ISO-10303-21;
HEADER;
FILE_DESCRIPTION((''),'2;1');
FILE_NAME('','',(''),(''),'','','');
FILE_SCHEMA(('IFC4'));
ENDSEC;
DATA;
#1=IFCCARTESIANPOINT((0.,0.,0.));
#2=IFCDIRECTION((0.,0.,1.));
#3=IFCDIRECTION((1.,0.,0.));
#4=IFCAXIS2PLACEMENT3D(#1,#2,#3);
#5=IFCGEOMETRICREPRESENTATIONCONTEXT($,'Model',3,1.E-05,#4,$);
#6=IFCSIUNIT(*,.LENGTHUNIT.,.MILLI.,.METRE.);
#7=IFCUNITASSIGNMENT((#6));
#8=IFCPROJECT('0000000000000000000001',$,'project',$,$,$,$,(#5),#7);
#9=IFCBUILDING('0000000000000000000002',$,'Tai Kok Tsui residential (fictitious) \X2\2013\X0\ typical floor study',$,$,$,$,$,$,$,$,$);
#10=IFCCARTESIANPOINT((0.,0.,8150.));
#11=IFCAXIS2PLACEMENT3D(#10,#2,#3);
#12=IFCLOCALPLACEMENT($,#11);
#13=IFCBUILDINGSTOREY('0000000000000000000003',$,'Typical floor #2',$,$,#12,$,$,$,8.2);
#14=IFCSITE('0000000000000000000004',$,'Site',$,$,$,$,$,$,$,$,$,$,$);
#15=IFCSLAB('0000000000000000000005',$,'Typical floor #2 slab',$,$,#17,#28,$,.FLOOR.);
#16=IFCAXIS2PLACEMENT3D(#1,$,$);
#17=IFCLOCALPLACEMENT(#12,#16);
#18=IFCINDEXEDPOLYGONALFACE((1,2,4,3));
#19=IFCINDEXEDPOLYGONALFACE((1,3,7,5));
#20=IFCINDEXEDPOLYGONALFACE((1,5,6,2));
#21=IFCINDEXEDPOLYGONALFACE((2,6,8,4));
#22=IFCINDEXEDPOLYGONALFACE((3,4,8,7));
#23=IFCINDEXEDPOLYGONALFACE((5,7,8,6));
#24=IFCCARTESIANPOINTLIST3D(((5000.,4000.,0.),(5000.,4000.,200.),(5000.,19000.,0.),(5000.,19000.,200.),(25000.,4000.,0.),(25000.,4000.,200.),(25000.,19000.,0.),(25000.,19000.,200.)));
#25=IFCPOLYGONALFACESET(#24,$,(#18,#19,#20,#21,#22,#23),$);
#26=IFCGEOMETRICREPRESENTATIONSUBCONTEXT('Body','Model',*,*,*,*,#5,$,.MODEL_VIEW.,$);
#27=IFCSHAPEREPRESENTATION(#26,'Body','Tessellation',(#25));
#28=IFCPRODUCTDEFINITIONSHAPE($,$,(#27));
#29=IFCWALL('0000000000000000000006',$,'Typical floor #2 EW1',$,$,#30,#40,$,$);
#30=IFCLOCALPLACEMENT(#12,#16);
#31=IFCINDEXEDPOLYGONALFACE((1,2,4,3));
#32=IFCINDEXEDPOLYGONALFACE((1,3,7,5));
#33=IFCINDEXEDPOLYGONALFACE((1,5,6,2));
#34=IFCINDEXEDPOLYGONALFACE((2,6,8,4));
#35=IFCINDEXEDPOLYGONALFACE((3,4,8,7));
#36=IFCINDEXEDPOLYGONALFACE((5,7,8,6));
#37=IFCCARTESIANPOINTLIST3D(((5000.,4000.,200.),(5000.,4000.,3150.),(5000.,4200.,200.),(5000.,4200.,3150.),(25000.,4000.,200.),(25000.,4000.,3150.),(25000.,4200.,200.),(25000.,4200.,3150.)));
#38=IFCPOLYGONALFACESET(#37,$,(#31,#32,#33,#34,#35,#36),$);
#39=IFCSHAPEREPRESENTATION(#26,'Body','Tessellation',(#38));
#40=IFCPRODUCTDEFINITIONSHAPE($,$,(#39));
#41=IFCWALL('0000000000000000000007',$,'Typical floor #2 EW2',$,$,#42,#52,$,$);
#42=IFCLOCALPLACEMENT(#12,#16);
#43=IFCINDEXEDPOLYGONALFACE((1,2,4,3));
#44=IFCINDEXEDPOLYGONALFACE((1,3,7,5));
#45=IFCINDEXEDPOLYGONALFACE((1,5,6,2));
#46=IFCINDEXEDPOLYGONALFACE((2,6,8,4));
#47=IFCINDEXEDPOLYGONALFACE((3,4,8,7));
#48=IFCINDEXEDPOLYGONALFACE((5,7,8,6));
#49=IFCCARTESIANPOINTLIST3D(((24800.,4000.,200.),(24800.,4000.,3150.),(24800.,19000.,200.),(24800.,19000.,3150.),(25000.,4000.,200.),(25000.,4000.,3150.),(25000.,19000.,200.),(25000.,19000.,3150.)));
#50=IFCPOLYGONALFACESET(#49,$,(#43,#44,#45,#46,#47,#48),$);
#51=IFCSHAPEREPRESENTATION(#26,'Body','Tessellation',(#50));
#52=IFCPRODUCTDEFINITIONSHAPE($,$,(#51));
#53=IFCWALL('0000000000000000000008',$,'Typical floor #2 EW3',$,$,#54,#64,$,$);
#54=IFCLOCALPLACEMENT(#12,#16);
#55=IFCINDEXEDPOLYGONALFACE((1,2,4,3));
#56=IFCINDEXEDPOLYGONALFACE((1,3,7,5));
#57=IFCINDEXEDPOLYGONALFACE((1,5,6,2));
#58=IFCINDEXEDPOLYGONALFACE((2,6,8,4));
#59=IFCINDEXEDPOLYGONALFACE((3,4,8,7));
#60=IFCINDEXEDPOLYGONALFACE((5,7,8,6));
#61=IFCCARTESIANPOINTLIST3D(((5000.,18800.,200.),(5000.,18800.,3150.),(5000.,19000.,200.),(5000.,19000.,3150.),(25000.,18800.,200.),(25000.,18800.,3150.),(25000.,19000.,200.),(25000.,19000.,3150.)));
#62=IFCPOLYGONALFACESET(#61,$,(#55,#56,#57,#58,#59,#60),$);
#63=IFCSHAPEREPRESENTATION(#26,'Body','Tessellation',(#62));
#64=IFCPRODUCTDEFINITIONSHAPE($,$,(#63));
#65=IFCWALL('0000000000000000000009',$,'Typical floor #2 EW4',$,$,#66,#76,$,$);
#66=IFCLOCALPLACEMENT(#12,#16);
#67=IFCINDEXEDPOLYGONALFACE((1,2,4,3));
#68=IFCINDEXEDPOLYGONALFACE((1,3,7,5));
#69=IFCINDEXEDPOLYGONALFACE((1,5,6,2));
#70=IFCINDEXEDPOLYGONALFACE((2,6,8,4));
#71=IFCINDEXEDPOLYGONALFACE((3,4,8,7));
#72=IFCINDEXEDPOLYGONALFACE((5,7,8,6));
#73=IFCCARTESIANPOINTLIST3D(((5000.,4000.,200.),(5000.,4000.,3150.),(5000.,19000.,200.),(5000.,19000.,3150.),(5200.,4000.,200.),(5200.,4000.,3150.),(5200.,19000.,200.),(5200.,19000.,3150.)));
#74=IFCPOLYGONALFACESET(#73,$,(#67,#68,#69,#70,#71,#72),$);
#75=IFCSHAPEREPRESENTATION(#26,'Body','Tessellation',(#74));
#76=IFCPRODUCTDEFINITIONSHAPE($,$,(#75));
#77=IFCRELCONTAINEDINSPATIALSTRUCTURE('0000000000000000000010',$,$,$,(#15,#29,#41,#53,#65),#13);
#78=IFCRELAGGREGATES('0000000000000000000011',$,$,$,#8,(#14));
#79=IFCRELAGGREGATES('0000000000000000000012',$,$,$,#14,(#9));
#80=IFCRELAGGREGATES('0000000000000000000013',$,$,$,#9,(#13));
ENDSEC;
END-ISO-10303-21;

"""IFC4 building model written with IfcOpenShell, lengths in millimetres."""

from ifc_helpers import new_model, si_unit, frame, origin_with_axes, place, context, subcontext, project, spatial, indexed_curve, outline, extrude, element, save


model = new_model("IFC4")

# Units and contexts
model_context = context("Model", 3, precision=1e-05, world=origin_with_axes())
body_context = subcontext(model_context, "Body", "Model", "MODEL_VIEW")
ifc_project = project(units=[si_unit("LENGTHUNIT", "METRE", prefix="MILLI")], contexts=[model_context])

# Site, building, storey
site = spatial("IfcSite", under=ifc_project, Name="Site")
building = spatial("IfcBuilding", under=site, Name="Tai Kok Tsui residential (fictitious) – typical floor study")
storey_placement = place(None, frame((0.0, 0.0, 8150.0), z_axis=(0.0, 0.0, 1.0), x_axis=(1.0, 0.0, 0.0)))
storey = spatial("IfcBuildingStorey", under=building, at=storey_placement, Name="Typical floor #2", Elevation=8.2)

# Slab
slab_placement = place(storey_placement, origin_with_axes())
element("IfcSlab", 1, at=slab_placement, inside=storey, Name="Typical floor #2 slab", PredefinedType="FLOOR", context=body_context, shape_type="SweptSolid", body=[
    extrude(outline(indexed_curve([(5000.0, 4000.0), (25000.0, 4000.0), (25000.0, 19000.0), (5000.0, 19000.0)])), None, (0.0, 0.0, 1.0), 200.0),
])

# Walls
wall_1_placement = place(storey_placement, frame((5000.0, 4000.0, 200.0), z_axis=(0.0, 0.0, 1.0), x_axis=(1.0, 0.0, 0.0)))
element("IfcWall", 2, at=wall_1_placement, inside=storey, Name="Typical floor #2 EW1", context=body_context, shape_type="SweptSolid", body=[
    extrude(outline(indexed_curve([(0.0, 0.0), (0.0, 200.0), (20000.0, 200.0), (20000.0, 0.0), (0.0, 0.0)], self_intersect=False)), origin_with_axes(), (0.0, 0.0, 1.0), 2950.0),
])
wall_2_placement = place(storey_placement, frame((25000.0, 4000.0, 200.0), z_axis=(0.0, 0.0, 1.0), x_axis=(0.0, 1.0, 0.0)))
element("IfcWall", 3, at=wall_2_placement, inside=storey, Name="Typical floor #2 EW2", context=body_context, shape_type="SweptSolid", body=[
    extrude(outline(indexed_curve([(0.0, 0.0), (0.0, 200.0), (15000.0, 200.0), (15000.0, 0.0), (0.0, 0.0)], self_intersect=False)), origin_with_axes(), (0.0, 0.0, 1.0), 2950.0),
])
wall_3_placement = place(storey_placement, frame((25000.0, 19000.0, 200.0), z_axis=(0.0, 0.0, 1.0), x_axis=(-1.0, 0.0, 0.0)))
element("IfcWall", 4, at=wall_3_placement, inside=storey, Name="Typical floor #2 EW3", context=body_context, shape_type="SweptSolid", body=[
    extrude(outline(indexed_curve([(0.0, 0.0), (0.0, 200.0), (20000.0, 200.0), (20000.0, 0.0), (0.0, 0.0)], self_intersect=False)), origin_with_axes(), (0.0, 0.0, 1.0), 2950.0),
])
wall_4_placement = place(storey_placement, frame((5000.0, 19000.0, 200.0), z_axis=(0.0, 0.0, 1.0), x_axis=(0.0, -1.0, 0.0)))
element("IfcWall", 5, at=wall_4_placement, inside=storey, Name="Typical floor #2 EW4", context=body_context, shape_type="SweptSolid", body=[
    extrude(outline(indexed_curve([(0.0, 0.0), (0.0, 200.0), (15000.0, 200.0), (15000.0, 0.0), (0.0, 0.0)], self_intersect=False)), origin_with_axes(), (0.0, 0.0, 1.0), 2950.0),
])

save(model, "model.ifc")
